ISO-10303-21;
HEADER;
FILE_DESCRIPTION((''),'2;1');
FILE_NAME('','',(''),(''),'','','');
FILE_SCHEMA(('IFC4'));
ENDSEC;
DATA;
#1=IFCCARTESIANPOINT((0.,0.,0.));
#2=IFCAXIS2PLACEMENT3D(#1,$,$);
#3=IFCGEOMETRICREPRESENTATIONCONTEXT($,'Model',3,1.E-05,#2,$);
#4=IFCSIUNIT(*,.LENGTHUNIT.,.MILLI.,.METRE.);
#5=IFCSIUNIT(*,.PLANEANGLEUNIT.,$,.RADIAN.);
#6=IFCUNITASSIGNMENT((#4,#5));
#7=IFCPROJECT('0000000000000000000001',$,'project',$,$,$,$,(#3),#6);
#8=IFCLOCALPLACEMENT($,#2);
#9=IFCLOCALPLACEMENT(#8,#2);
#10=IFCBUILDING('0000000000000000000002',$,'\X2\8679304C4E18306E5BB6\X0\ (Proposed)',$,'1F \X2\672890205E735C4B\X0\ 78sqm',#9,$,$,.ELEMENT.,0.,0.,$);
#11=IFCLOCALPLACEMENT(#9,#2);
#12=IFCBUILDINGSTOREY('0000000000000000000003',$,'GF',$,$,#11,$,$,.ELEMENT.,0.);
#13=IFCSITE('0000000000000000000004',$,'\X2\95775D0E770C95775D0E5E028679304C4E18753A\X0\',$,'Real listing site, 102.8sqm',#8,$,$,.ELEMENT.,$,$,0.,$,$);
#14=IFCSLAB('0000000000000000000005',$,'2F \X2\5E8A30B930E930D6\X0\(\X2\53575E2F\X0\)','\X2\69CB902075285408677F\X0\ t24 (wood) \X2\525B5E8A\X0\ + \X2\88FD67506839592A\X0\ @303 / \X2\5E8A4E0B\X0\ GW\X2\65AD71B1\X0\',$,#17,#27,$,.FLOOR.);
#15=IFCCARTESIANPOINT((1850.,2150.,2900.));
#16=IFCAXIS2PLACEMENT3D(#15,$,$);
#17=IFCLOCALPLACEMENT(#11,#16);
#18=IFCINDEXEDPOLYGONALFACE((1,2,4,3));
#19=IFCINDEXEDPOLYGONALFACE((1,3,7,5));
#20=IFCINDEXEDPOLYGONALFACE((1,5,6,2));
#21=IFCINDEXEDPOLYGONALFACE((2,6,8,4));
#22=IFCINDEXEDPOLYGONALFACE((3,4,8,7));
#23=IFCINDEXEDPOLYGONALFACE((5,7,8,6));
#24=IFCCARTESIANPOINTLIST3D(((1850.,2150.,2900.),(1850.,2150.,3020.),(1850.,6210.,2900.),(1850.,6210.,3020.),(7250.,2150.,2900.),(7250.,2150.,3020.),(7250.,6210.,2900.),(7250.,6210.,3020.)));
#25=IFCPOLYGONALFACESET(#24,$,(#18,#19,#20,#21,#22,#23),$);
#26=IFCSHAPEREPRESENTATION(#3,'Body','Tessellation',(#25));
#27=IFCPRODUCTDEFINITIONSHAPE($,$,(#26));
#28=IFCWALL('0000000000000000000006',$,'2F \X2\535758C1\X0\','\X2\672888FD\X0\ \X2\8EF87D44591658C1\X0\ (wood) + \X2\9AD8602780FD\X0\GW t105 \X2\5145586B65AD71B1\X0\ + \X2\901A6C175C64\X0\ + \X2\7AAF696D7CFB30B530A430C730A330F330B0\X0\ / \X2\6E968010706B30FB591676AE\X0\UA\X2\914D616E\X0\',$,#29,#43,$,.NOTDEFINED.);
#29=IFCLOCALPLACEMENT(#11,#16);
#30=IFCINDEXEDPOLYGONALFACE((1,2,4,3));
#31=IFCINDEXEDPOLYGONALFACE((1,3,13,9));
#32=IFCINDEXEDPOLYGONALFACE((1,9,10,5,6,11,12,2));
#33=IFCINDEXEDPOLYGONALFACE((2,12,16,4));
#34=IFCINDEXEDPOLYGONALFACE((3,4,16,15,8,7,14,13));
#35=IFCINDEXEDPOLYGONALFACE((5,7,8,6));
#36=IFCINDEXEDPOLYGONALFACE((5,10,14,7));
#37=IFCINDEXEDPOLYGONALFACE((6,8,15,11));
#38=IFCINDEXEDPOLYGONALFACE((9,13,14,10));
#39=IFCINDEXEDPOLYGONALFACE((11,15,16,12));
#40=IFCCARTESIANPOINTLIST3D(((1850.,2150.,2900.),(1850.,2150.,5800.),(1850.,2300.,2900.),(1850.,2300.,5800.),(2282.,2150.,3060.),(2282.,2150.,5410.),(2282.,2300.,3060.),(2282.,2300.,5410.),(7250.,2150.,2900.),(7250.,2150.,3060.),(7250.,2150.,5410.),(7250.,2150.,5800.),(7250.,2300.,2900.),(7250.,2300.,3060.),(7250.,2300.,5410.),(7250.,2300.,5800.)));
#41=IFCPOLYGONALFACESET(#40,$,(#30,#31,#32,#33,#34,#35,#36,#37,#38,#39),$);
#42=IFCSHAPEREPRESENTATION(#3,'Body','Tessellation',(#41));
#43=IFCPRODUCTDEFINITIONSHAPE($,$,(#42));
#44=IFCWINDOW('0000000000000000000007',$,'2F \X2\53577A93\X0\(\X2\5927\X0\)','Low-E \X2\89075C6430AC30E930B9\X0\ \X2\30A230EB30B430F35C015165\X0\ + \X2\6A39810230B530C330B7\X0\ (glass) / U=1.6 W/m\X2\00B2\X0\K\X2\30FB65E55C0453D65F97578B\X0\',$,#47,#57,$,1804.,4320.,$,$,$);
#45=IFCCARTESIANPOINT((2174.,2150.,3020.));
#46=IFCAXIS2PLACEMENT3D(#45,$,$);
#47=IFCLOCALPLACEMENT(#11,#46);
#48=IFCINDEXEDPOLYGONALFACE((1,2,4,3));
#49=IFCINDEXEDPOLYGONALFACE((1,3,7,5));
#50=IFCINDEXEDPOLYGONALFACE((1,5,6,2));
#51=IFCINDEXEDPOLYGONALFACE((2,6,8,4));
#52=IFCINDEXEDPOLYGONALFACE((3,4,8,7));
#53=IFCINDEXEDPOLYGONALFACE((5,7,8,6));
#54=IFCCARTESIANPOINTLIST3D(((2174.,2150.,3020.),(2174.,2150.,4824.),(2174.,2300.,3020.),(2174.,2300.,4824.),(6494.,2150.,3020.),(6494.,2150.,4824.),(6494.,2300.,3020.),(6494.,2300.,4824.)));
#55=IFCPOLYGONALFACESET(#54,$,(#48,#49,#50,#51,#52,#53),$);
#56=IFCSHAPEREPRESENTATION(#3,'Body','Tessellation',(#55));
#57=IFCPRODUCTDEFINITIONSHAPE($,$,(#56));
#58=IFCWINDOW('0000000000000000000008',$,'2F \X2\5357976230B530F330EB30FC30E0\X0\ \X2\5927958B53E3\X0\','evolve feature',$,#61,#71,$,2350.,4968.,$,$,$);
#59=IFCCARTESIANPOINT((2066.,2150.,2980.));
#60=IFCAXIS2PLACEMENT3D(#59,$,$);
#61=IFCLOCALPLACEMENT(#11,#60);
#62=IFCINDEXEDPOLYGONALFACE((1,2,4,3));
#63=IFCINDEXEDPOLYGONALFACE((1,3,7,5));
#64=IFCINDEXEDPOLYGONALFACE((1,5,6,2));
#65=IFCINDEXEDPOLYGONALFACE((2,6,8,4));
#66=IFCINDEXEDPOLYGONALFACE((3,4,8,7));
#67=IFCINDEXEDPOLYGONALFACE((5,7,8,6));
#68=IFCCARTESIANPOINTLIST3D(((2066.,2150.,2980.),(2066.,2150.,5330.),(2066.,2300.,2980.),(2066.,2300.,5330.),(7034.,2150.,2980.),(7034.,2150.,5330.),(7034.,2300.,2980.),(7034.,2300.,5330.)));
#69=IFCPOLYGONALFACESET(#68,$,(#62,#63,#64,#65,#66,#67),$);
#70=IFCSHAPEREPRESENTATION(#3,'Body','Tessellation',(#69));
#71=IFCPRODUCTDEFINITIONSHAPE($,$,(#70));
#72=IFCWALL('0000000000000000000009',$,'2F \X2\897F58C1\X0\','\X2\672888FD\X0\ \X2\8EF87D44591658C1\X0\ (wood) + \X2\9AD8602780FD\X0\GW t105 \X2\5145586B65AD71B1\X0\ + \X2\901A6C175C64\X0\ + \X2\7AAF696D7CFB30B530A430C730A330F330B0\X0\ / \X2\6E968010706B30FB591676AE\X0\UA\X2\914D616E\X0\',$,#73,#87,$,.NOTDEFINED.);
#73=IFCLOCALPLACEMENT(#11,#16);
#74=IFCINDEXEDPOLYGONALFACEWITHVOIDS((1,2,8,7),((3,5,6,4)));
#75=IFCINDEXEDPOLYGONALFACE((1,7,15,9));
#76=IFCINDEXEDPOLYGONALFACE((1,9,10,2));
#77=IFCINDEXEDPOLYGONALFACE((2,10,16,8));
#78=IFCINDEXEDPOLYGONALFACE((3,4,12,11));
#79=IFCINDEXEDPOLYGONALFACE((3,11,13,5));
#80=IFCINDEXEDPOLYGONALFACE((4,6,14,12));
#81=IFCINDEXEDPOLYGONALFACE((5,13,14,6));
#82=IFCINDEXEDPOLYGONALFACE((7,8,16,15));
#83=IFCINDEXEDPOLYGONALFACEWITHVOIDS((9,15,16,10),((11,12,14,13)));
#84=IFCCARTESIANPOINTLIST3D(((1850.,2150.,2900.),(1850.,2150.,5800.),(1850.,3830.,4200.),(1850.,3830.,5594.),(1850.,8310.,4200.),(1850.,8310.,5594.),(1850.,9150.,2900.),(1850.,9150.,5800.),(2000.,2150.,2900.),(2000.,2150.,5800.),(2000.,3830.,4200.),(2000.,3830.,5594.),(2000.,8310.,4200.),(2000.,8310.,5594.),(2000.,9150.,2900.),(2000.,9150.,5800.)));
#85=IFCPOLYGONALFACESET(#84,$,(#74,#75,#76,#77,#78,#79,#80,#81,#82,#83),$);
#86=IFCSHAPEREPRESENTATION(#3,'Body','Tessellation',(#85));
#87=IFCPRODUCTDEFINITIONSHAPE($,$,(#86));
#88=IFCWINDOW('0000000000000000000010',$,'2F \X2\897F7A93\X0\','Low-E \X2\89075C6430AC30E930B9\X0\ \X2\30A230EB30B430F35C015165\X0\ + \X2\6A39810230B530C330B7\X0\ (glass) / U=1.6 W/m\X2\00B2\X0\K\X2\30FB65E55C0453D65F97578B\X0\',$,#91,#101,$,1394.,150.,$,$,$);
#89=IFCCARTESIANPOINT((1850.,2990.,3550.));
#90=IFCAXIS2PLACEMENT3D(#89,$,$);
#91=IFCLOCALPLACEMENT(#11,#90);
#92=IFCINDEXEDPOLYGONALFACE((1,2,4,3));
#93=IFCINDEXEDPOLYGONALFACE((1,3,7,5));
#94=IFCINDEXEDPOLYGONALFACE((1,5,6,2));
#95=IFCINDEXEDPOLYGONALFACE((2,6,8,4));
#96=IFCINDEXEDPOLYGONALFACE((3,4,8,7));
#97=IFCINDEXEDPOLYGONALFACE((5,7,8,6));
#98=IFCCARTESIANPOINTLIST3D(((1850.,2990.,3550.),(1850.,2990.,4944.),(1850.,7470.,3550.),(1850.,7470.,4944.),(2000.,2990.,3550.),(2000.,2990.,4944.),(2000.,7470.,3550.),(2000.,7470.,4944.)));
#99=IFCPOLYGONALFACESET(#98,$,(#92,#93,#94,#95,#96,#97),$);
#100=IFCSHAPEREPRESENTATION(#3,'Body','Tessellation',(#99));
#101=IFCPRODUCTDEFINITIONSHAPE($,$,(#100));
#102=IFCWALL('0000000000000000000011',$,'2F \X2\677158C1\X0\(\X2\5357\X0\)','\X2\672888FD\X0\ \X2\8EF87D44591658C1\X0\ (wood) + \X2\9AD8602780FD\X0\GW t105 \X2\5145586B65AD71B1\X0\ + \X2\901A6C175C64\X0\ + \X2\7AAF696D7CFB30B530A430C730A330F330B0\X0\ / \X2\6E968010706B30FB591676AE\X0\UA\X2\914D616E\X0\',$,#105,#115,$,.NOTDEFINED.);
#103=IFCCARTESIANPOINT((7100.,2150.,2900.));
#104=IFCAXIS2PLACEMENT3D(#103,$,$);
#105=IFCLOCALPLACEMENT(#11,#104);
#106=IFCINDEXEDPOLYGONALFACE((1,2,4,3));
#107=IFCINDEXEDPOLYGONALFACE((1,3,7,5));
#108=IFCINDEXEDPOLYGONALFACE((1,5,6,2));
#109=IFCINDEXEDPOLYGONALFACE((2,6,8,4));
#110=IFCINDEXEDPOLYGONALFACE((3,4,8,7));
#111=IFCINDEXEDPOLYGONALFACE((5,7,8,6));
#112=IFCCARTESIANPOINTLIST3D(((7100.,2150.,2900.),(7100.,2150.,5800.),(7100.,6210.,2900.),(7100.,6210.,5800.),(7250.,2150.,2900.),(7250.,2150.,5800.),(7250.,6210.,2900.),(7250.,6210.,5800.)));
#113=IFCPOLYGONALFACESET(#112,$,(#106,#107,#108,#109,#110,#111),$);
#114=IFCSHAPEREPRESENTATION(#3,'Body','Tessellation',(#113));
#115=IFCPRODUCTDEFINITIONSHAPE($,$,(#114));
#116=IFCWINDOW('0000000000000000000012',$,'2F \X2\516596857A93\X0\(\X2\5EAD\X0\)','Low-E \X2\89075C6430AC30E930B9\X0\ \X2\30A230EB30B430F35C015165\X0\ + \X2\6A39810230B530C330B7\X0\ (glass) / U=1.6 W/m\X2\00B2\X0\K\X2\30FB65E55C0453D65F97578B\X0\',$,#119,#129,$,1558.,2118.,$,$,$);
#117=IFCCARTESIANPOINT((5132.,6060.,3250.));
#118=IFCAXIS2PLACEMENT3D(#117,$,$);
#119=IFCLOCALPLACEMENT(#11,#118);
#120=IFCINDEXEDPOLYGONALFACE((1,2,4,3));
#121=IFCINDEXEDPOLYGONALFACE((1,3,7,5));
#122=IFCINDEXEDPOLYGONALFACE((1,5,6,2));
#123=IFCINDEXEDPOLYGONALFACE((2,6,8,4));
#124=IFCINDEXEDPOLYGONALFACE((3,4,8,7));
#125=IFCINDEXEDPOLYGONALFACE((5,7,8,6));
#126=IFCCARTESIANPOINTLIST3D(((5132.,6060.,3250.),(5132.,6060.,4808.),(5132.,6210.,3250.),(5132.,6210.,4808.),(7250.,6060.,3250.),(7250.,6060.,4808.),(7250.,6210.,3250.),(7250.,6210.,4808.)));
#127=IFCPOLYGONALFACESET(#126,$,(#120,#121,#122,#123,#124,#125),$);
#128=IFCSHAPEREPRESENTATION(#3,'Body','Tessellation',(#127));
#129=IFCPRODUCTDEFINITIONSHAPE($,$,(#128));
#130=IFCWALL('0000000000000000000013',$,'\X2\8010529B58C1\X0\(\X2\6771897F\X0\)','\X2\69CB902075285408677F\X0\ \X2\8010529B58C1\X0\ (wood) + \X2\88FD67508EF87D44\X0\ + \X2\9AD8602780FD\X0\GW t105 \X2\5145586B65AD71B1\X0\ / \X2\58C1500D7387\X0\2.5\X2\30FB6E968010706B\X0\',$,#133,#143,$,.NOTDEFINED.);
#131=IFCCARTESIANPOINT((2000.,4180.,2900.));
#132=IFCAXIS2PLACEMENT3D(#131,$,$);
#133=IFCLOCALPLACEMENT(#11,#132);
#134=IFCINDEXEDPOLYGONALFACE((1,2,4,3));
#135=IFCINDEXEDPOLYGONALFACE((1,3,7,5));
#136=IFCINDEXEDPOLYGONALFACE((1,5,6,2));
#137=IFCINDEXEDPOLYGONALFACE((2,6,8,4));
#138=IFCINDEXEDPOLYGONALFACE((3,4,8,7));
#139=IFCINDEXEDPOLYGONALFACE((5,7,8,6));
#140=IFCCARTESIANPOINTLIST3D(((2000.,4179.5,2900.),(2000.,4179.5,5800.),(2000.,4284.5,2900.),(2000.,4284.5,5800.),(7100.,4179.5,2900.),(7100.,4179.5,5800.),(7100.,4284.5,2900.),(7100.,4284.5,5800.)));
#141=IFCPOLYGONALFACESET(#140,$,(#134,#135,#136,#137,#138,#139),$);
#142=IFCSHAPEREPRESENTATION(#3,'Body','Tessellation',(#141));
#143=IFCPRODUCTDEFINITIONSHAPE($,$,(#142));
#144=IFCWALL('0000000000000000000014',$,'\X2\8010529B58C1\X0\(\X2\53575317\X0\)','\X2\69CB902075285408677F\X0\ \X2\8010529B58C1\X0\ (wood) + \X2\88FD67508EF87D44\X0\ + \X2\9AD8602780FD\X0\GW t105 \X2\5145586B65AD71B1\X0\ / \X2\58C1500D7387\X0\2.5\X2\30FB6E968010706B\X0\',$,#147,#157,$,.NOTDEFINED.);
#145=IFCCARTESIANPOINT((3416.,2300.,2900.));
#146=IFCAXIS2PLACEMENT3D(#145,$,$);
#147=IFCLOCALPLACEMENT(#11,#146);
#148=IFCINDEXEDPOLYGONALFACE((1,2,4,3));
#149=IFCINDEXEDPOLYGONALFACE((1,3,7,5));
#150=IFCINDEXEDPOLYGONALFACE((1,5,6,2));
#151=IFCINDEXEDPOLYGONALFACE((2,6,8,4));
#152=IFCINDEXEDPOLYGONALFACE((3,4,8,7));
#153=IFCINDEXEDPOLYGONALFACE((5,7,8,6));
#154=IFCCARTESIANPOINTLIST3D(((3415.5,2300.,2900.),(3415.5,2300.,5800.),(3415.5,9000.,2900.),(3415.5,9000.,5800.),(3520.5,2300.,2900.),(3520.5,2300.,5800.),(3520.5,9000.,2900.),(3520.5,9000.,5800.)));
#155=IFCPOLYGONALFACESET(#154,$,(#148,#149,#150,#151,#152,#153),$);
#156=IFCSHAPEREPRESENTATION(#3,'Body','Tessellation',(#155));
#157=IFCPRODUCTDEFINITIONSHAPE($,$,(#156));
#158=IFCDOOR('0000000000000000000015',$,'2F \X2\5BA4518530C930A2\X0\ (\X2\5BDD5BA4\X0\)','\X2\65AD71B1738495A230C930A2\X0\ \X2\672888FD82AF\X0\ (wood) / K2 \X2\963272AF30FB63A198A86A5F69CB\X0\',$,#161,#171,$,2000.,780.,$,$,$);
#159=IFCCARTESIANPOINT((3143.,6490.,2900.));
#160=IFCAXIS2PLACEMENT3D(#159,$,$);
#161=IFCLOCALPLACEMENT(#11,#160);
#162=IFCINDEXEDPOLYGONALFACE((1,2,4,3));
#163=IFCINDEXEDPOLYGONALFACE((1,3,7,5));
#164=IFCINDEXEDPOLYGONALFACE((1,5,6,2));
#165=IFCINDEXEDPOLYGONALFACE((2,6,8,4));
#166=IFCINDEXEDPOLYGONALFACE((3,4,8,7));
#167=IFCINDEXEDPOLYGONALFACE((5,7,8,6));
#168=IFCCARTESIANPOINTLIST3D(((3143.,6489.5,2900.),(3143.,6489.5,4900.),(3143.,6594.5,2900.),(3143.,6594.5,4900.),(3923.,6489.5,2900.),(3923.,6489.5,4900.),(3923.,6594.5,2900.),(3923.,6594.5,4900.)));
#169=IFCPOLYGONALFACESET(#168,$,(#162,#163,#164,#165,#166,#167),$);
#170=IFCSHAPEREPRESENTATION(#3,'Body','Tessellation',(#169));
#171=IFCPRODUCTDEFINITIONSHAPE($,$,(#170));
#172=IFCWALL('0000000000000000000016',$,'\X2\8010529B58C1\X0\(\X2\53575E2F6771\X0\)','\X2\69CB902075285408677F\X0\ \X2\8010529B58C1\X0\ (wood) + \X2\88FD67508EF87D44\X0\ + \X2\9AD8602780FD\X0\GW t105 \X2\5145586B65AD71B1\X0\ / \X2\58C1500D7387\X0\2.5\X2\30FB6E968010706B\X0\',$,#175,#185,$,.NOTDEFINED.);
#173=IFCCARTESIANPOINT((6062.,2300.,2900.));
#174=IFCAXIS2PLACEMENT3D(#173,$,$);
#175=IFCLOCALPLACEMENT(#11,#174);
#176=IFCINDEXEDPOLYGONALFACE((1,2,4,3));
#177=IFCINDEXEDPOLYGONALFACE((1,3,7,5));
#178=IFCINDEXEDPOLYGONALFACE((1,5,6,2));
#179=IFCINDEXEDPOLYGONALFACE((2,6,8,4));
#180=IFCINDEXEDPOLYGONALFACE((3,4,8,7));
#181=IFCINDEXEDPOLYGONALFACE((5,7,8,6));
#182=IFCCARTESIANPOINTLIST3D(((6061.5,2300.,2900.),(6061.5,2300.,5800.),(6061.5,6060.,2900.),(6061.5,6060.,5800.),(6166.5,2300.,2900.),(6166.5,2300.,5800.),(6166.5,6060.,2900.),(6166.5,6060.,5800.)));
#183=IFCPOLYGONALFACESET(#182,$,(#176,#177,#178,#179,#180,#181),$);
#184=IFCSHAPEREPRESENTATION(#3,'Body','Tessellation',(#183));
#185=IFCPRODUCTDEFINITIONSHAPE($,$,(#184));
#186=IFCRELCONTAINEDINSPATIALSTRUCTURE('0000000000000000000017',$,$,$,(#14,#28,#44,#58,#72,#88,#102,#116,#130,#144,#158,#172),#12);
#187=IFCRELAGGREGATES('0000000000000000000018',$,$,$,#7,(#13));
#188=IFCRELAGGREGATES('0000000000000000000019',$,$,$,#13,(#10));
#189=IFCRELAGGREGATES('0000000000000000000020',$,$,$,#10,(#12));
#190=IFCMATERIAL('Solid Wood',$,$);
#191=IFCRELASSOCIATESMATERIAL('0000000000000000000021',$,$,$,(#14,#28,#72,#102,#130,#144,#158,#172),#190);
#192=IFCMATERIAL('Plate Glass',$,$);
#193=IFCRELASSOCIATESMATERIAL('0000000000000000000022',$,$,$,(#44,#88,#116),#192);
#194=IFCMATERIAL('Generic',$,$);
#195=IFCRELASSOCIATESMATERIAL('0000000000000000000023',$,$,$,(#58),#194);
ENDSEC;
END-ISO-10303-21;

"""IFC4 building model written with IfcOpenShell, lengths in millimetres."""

from ifc_helpers import new_model, si_unit, frame, frame_2d, origin, place, context, project, spatial, rectangle, extrude, material, element, fill, save


model = new_model("IFC4")

# Units and contexts
model_context = context("Model", 3, precision=1e-05, world=origin())
ifc_project = project(units=[si_unit("LENGTHUNIT", "METRE", prefix="MILLI"), si_unit("PLANEANGLEUNIT", "RADIAN")], contexts=[model_context])

# Site, building, storey
site_placement = place(None, origin())
site = spatial("IfcSite", under=ifc_project, at=site_placement, Name="長崎県長崎市虹が丘町", ObjectType="Real listing site, 102.8sqm", CompositionType="ELEMENT", RefElevation=0.0)
building_placement = place(site_placement, origin())
building = spatial("IfcBuilding", under=site, at=building_placement, Name="虹が丘の家 (Proposed)", ObjectType="1F 木造平屋 78sqm", CompositionType="ELEMENT", ElevationOfRefHeight=0.0, ElevationOfTerrain=0.0)
storey_placement = place(building_placement, origin())
storey = spatial("IfcBuildingStorey", under=building, at=storey_placement, Name="GF", CompositionType="ELEMENT", Elevation=0.0)

# Slab
ifc_material_1 = material(Name="Solid Wood")
slab_placement = place(storey_placement, frame((1850.0, 2150.0, 2900.0)))
element("IfcSlab", 1, at=slab_placement, inside=storey, material=ifc_material_1, Name="2F 床スラブ(南帯)", Description="構造用合板 t24 (wood) 剛床 + 製材根太 @303 / 床下 GW断熱", PredefinedType="FLOOR", context=model_context, shape_type="SweptSolid", body=[
    extrude(rectangle(XDim=5400.0, YDim=4060.0, at=frame_2d((2700.0, 2030.0))), frame((1850.0, 2150.0, 2900.0)), (0.0, 0.0, 1.0), 120.0),
])

# Wall, openings, windows
wall_1_placement = place(storey_placement, frame((1850.0, 2150.0, 2900.0)))
wall_1 = element("IfcWall", 2, at=wall_1_placement, inside=storey, material=ifc_material_1, Name="2F 南壁", Description="木製 軸組外壁 (wood) + 高性能GW t105 充填断熱 + 通気層 + 窯業系サイディング / 準耐火・外皮UA配慮", PredefinedType="NOTDEFINED", context=model_context, shape_type="SweptSolid", body=[
    extrude(rectangle(XDim=5400.0, YDim=150.0, at=frame_2d((2700.0, 75.0))), frame((1850.0, 2150.0, 2900.0)), (0.0, 0.0, 1.0), 2900.0),
])
opening_1_placement = place(storey_placement, frame((2174.0, 2150.0, 3020.0)))
opening_1 = element("IfcOpeningElement", 3, at=opening_1_placement, cuts=wall_1, PredefinedType="NOTDEFINED", context=model_context, shape_type="SweptSolid", body=[
    extrude(rectangle(XDim=4320.0, YDim=150.0, at=frame_2d((2160.0, 75.0))), frame((2174.0, 2150.0, 3020.0)), (0.0, 0.0, 1.0), 1804.0),
])
opening_2_placement = place(storey_placement, frame((2066.0, 2150.0, 2980.0)))
opening_2 = element("IfcOpeningElement", 4, at=opening_2_placement, cuts=wall_1, PredefinedType="NOTDEFINED", context=model_context, shape_type="SweptSolid", body=[
    extrude(rectangle(XDim=4968.0, YDim=150.0, at=frame_2d((2484.0, 75.0))), frame((2066.0, 2150.0, 2980.0)), (0.0, 0.0, 1.0), 2350.0),
])
ifc_material_2 = material(Name="Plate Glass")
window_1_placement = place(storey_placement, frame((2174.0, 2150.0, 3020.0)))
window_1 = element("IfcWindow", 5, at=window_1_placement, inside=storey, material=ifc_material_2, Name="2F 南窓(大)", Description="Low-E 複層ガラス アルゴン封入 + 樹脂サッシ (glass) / U=1.6 W/m²K・日射取得型", OverallHeight=1804.0, OverallWidth=4320.0, context=model_context, shape_type="SweptSolid", body=[
    extrude(rectangle(XDim=4320.0, YDim=150.0, at=frame_2d((2160.0, 75.0))), frame((2174.0, 2150.0, 3020.0)), (0.0, 0.0, 1.0), 1804.0),
])
fill(opening_1, window_1)
ifc_material_3 = material(Name="Generic")
window_2_placement = place(storey_placement, frame((2066.0, 2150.0, 2980.0)))
window_2 = element("IfcWindow", 6, at=window_2_placement, inside=storey, material=ifc_material_3, Name="2F 南面サンルーム 大開口", Description="evolve feature", OverallHeight=2350.0, OverallWidth=4968.0, context=model_context, shape_type="SweptSolid", body=[
    extrude(rectangle(XDim=4968.0, YDim=150.0, at=frame_2d((2484.0, 75.0))), frame((2066.0, 2150.0, 2980.0)), (0.0, 0.0, 1.0), 2350.0),
])
fill(opening_2, window_2)

# Walls, openings, windows
wall_2_placement = place(storey_placement, frame((1850.0, 2150.0, 2900.0)))
wall_2 = element("IfcWall", 7, at=wall_2_placement, inside=storey, material=ifc_material_1, Name="2F 西壁", Description="木製 軸組外壁 (wood) + 高性能GW t105 充填断熱 + 通気層 + 窯業系サイディング / 準耐火・外皮UA配慮", PredefinedType="NOTDEFINED", context=model_context, shape_type="SweptSolid", body=[
    extrude(rectangle(XDim=150.0, YDim=7000.0, at=frame_2d((75.0, 3500.0))), frame((1850.0, 2150.0, 2900.0)), (0.0, 0.0, 1.0), 2900.0),
])
opening_3_placement = place(storey_placement, frame((1850.0, 2990.0, 3550.0)))
opening_3 = element("IfcOpeningElement", 8, at=opening_3_placement, cuts=wall_2, PredefinedType="NOTDEFINED", context=model_context, shape_type="SweptSolid", body=[
    extrude(rectangle(XDim=150.0, YDim=4480.0, at=frame_2d((75.0, 2240.0))), frame((1850.0, 2990.0, 3550.0)), (0.0, 0.0, 1.0), 1394.0),
])
window_3_placement = place(storey_placement, frame((1850.0, 2990.0, 3550.0)))
window_3 = element("IfcWindow", 9, at=window_3_placement, inside=storey, material=ifc_material_2, Name="2F 西窓", Description="Low-E 複層ガラス アルゴン封入 + 樹脂サッシ (glass) / U=1.6 W/m²K・日射取得型", OverallHeight=1394.0, OverallWidth=150.0, context=model_context, shape_type="SweptSolid", body=[
    extrude(rectangle(XDim=150.0, YDim=4480.0, at=frame_2d((75.0, 2240.0))), frame((1850.0, 2990.0, 3550.0)), (0.0, 0.0, 1.0), 1394.0),
])
fill(opening_3, window_3)
wall_3_placement = place(storey_placement, frame((7100.0, 2150.0, 2900.0)))
wall_3 = element("IfcWall", 10, at=wall_3_placement, inside=storey, material=ifc_material_1, Name="2F 東壁(南)", Description="木製 軸組外壁 (wood) + 高性能GW t105 充填断熱 + 通気層 + 窯業系サイディング / 準耐火・外皮UA配慮", PredefinedType="NOTDEFINED", context=model_context, shape_type="SweptSolid", body=[
    extrude(rectangle(XDim=150.0, YDim=4060.0, at=frame_2d((75.0, 2030.0))), frame((7100.0, 2150.0, 2900.0)), (0.0, 0.0, 1.0), 2900.0),
])
opening_4_placement = place(storey_placement, frame((5132.0, 6060.0, 3250.0)))
opening_4 = element("IfcOpeningElement", 11, at=opening_4_placement, cuts=wall_3, PredefinedType="NOTDEFINED", context=model_context, shape_type="SweptSolid", body=[
    extrude(rectangle(XDim=2118.0, YDim=150.0, at=frame_2d((1059.0, 75.0))), frame((5132.0, 6060.0, 3250.0)), (0.0, 0.0, 1.0), 1558.0),
])
window_4_placement = place(storey_placement, frame((5132.0, 6060.0, 3250.0)))
window_4 = element("IfcWindow", 12, at=window_4_placement, inside=storey, material=ifc_material_2, Name="2F 入隅窓(庭)", Description="Low-E 複層ガラス アルゴン封入 + 樹脂サッシ (glass) / U=1.6 W/m²K・日射取得型", OverallHeight=1558.0, OverallWidth=2118.0, context=model_context, shape_type="SweptSolid", body=[
    extrude(rectangle(XDim=2118.0, YDim=150.0, at=frame_2d((1059.0, 75.0))), frame((5132.0, 6060.0, 3250.0)), (0.0, 0.0, 1.0), 1558.0),
])
fill(opening_4, window_4)

# Wall
wall_4_placement = place(storey_placement, frame((2000.0, 4180.0, 2900.0)))
element("IfcWall", 13, at=wall_4_placement, inside=storey, material=ifc_material_1, Name="耐力壁(東西)", Description="構造用合板 耐力壁 (wood) + 製材軸組 + 高性能GW t105 充填断熱 / 壁倍率2.5・準耐火", PredefinedType="NOTDEFINED", context=model_context, shape_type="SweptSolid", body=[
    extrude(rectangle(XDim=5100.0, YDim=105.0, at=frame_2d((2550.0, 52.0))), frame((2000.0, 4180.0, 2900.0)), (0.0, 0.0, 1.0), 2900.0),
])

# Wall, opening, door
wall_5_placement = place(storey_placement, frame((3416.0, 2300.0, 2900.0)))
wall_5 = element("IfcWall", 14, at=wall_5_placement, inside=storey, material=ifc_material_1, Name="耐力壁(南北)", Description="構造用合板 耐力壁 (wood) + 製材軸組 + 高性能GW t105 充填断熱 / 壁倍率2.5・準耐火", PredefinedType="NOTDEFINED", context=model_context, shape_type="SweptSolid", body=[
    extrude(rectangle(XDim=105.0, YDim=6700.0, at=frame_2d((52.0, 3350.0))), frame((3416.0, 2300.0, 2900.0)), (0.0, 0.0, 1.0), 2900.0),
])
opening_5_placement = place(storey_placement, frame((3143.0, 6490.0, 2900.0)))
opening_5 = element("IfcOpeningElement", 15, at=opening_5_placement, cuts=wall_5, PredefinedType="NOTDEFINED", context=model_context, shape_type="SweptSolid", body=[
    extrude(rectangle(XDim=780.0, YDim=105.0, at=frame_2d((390.0, 52.0))), frame((3143.0, 6490.0, 2900.0)), (0.0, 0.0, 1.0), 2000.0),
])
door_placement = place(storey_placement, frame((3143.0, 6490.0, 2900.0)))
door = element("IfcDoor", 16, at=door_placement, inside=storey, material=ifc_material_1, Name="2F 室内ドア (寝室)", Description="断熱玄関ドア 木製芯 (wood) / K2 防犯・採風機構", OverallHeight=2000.0, OverallWidth=780.0, context=model_context, shape_type="SweptSolid", body=[
    extrude(rectangle(XDim=780.0, YDim=105.0, at=frame_2d((390.0, 52.0))), frame((3143.0, 6490.0, 2900.0)), (0.0, 0.0, 1.0), 2000.0),
])
fill(opening_5, door)

# Wall
wall_6_placement = place(storey_placement, frame((6062.0, 2300.0, 2900.0)))
element("IfcWall", 17, at=wall_6_placement, inside=storey, material=ifc_material_1, Name="耐力壁(南帯東)", Description="構造用合板 耐力壁 (wood) + 製材軸組 + 高性能GW t105 充填断熱 / 壁倍率2.5・準耐火", PredefinedType="NOTDEFINED", context=model_context, shape_type="SweptSolid", body=[
    extrude(rectangle(XDim=105.0, YDim=3760.0, at=frame_2d((52.0, 1880.0))), frame((6062.0, 2300.0, 2900.0)), (0.0, 0.0, 1.0), 2900.0),
])

save(model, "model.ifc")
